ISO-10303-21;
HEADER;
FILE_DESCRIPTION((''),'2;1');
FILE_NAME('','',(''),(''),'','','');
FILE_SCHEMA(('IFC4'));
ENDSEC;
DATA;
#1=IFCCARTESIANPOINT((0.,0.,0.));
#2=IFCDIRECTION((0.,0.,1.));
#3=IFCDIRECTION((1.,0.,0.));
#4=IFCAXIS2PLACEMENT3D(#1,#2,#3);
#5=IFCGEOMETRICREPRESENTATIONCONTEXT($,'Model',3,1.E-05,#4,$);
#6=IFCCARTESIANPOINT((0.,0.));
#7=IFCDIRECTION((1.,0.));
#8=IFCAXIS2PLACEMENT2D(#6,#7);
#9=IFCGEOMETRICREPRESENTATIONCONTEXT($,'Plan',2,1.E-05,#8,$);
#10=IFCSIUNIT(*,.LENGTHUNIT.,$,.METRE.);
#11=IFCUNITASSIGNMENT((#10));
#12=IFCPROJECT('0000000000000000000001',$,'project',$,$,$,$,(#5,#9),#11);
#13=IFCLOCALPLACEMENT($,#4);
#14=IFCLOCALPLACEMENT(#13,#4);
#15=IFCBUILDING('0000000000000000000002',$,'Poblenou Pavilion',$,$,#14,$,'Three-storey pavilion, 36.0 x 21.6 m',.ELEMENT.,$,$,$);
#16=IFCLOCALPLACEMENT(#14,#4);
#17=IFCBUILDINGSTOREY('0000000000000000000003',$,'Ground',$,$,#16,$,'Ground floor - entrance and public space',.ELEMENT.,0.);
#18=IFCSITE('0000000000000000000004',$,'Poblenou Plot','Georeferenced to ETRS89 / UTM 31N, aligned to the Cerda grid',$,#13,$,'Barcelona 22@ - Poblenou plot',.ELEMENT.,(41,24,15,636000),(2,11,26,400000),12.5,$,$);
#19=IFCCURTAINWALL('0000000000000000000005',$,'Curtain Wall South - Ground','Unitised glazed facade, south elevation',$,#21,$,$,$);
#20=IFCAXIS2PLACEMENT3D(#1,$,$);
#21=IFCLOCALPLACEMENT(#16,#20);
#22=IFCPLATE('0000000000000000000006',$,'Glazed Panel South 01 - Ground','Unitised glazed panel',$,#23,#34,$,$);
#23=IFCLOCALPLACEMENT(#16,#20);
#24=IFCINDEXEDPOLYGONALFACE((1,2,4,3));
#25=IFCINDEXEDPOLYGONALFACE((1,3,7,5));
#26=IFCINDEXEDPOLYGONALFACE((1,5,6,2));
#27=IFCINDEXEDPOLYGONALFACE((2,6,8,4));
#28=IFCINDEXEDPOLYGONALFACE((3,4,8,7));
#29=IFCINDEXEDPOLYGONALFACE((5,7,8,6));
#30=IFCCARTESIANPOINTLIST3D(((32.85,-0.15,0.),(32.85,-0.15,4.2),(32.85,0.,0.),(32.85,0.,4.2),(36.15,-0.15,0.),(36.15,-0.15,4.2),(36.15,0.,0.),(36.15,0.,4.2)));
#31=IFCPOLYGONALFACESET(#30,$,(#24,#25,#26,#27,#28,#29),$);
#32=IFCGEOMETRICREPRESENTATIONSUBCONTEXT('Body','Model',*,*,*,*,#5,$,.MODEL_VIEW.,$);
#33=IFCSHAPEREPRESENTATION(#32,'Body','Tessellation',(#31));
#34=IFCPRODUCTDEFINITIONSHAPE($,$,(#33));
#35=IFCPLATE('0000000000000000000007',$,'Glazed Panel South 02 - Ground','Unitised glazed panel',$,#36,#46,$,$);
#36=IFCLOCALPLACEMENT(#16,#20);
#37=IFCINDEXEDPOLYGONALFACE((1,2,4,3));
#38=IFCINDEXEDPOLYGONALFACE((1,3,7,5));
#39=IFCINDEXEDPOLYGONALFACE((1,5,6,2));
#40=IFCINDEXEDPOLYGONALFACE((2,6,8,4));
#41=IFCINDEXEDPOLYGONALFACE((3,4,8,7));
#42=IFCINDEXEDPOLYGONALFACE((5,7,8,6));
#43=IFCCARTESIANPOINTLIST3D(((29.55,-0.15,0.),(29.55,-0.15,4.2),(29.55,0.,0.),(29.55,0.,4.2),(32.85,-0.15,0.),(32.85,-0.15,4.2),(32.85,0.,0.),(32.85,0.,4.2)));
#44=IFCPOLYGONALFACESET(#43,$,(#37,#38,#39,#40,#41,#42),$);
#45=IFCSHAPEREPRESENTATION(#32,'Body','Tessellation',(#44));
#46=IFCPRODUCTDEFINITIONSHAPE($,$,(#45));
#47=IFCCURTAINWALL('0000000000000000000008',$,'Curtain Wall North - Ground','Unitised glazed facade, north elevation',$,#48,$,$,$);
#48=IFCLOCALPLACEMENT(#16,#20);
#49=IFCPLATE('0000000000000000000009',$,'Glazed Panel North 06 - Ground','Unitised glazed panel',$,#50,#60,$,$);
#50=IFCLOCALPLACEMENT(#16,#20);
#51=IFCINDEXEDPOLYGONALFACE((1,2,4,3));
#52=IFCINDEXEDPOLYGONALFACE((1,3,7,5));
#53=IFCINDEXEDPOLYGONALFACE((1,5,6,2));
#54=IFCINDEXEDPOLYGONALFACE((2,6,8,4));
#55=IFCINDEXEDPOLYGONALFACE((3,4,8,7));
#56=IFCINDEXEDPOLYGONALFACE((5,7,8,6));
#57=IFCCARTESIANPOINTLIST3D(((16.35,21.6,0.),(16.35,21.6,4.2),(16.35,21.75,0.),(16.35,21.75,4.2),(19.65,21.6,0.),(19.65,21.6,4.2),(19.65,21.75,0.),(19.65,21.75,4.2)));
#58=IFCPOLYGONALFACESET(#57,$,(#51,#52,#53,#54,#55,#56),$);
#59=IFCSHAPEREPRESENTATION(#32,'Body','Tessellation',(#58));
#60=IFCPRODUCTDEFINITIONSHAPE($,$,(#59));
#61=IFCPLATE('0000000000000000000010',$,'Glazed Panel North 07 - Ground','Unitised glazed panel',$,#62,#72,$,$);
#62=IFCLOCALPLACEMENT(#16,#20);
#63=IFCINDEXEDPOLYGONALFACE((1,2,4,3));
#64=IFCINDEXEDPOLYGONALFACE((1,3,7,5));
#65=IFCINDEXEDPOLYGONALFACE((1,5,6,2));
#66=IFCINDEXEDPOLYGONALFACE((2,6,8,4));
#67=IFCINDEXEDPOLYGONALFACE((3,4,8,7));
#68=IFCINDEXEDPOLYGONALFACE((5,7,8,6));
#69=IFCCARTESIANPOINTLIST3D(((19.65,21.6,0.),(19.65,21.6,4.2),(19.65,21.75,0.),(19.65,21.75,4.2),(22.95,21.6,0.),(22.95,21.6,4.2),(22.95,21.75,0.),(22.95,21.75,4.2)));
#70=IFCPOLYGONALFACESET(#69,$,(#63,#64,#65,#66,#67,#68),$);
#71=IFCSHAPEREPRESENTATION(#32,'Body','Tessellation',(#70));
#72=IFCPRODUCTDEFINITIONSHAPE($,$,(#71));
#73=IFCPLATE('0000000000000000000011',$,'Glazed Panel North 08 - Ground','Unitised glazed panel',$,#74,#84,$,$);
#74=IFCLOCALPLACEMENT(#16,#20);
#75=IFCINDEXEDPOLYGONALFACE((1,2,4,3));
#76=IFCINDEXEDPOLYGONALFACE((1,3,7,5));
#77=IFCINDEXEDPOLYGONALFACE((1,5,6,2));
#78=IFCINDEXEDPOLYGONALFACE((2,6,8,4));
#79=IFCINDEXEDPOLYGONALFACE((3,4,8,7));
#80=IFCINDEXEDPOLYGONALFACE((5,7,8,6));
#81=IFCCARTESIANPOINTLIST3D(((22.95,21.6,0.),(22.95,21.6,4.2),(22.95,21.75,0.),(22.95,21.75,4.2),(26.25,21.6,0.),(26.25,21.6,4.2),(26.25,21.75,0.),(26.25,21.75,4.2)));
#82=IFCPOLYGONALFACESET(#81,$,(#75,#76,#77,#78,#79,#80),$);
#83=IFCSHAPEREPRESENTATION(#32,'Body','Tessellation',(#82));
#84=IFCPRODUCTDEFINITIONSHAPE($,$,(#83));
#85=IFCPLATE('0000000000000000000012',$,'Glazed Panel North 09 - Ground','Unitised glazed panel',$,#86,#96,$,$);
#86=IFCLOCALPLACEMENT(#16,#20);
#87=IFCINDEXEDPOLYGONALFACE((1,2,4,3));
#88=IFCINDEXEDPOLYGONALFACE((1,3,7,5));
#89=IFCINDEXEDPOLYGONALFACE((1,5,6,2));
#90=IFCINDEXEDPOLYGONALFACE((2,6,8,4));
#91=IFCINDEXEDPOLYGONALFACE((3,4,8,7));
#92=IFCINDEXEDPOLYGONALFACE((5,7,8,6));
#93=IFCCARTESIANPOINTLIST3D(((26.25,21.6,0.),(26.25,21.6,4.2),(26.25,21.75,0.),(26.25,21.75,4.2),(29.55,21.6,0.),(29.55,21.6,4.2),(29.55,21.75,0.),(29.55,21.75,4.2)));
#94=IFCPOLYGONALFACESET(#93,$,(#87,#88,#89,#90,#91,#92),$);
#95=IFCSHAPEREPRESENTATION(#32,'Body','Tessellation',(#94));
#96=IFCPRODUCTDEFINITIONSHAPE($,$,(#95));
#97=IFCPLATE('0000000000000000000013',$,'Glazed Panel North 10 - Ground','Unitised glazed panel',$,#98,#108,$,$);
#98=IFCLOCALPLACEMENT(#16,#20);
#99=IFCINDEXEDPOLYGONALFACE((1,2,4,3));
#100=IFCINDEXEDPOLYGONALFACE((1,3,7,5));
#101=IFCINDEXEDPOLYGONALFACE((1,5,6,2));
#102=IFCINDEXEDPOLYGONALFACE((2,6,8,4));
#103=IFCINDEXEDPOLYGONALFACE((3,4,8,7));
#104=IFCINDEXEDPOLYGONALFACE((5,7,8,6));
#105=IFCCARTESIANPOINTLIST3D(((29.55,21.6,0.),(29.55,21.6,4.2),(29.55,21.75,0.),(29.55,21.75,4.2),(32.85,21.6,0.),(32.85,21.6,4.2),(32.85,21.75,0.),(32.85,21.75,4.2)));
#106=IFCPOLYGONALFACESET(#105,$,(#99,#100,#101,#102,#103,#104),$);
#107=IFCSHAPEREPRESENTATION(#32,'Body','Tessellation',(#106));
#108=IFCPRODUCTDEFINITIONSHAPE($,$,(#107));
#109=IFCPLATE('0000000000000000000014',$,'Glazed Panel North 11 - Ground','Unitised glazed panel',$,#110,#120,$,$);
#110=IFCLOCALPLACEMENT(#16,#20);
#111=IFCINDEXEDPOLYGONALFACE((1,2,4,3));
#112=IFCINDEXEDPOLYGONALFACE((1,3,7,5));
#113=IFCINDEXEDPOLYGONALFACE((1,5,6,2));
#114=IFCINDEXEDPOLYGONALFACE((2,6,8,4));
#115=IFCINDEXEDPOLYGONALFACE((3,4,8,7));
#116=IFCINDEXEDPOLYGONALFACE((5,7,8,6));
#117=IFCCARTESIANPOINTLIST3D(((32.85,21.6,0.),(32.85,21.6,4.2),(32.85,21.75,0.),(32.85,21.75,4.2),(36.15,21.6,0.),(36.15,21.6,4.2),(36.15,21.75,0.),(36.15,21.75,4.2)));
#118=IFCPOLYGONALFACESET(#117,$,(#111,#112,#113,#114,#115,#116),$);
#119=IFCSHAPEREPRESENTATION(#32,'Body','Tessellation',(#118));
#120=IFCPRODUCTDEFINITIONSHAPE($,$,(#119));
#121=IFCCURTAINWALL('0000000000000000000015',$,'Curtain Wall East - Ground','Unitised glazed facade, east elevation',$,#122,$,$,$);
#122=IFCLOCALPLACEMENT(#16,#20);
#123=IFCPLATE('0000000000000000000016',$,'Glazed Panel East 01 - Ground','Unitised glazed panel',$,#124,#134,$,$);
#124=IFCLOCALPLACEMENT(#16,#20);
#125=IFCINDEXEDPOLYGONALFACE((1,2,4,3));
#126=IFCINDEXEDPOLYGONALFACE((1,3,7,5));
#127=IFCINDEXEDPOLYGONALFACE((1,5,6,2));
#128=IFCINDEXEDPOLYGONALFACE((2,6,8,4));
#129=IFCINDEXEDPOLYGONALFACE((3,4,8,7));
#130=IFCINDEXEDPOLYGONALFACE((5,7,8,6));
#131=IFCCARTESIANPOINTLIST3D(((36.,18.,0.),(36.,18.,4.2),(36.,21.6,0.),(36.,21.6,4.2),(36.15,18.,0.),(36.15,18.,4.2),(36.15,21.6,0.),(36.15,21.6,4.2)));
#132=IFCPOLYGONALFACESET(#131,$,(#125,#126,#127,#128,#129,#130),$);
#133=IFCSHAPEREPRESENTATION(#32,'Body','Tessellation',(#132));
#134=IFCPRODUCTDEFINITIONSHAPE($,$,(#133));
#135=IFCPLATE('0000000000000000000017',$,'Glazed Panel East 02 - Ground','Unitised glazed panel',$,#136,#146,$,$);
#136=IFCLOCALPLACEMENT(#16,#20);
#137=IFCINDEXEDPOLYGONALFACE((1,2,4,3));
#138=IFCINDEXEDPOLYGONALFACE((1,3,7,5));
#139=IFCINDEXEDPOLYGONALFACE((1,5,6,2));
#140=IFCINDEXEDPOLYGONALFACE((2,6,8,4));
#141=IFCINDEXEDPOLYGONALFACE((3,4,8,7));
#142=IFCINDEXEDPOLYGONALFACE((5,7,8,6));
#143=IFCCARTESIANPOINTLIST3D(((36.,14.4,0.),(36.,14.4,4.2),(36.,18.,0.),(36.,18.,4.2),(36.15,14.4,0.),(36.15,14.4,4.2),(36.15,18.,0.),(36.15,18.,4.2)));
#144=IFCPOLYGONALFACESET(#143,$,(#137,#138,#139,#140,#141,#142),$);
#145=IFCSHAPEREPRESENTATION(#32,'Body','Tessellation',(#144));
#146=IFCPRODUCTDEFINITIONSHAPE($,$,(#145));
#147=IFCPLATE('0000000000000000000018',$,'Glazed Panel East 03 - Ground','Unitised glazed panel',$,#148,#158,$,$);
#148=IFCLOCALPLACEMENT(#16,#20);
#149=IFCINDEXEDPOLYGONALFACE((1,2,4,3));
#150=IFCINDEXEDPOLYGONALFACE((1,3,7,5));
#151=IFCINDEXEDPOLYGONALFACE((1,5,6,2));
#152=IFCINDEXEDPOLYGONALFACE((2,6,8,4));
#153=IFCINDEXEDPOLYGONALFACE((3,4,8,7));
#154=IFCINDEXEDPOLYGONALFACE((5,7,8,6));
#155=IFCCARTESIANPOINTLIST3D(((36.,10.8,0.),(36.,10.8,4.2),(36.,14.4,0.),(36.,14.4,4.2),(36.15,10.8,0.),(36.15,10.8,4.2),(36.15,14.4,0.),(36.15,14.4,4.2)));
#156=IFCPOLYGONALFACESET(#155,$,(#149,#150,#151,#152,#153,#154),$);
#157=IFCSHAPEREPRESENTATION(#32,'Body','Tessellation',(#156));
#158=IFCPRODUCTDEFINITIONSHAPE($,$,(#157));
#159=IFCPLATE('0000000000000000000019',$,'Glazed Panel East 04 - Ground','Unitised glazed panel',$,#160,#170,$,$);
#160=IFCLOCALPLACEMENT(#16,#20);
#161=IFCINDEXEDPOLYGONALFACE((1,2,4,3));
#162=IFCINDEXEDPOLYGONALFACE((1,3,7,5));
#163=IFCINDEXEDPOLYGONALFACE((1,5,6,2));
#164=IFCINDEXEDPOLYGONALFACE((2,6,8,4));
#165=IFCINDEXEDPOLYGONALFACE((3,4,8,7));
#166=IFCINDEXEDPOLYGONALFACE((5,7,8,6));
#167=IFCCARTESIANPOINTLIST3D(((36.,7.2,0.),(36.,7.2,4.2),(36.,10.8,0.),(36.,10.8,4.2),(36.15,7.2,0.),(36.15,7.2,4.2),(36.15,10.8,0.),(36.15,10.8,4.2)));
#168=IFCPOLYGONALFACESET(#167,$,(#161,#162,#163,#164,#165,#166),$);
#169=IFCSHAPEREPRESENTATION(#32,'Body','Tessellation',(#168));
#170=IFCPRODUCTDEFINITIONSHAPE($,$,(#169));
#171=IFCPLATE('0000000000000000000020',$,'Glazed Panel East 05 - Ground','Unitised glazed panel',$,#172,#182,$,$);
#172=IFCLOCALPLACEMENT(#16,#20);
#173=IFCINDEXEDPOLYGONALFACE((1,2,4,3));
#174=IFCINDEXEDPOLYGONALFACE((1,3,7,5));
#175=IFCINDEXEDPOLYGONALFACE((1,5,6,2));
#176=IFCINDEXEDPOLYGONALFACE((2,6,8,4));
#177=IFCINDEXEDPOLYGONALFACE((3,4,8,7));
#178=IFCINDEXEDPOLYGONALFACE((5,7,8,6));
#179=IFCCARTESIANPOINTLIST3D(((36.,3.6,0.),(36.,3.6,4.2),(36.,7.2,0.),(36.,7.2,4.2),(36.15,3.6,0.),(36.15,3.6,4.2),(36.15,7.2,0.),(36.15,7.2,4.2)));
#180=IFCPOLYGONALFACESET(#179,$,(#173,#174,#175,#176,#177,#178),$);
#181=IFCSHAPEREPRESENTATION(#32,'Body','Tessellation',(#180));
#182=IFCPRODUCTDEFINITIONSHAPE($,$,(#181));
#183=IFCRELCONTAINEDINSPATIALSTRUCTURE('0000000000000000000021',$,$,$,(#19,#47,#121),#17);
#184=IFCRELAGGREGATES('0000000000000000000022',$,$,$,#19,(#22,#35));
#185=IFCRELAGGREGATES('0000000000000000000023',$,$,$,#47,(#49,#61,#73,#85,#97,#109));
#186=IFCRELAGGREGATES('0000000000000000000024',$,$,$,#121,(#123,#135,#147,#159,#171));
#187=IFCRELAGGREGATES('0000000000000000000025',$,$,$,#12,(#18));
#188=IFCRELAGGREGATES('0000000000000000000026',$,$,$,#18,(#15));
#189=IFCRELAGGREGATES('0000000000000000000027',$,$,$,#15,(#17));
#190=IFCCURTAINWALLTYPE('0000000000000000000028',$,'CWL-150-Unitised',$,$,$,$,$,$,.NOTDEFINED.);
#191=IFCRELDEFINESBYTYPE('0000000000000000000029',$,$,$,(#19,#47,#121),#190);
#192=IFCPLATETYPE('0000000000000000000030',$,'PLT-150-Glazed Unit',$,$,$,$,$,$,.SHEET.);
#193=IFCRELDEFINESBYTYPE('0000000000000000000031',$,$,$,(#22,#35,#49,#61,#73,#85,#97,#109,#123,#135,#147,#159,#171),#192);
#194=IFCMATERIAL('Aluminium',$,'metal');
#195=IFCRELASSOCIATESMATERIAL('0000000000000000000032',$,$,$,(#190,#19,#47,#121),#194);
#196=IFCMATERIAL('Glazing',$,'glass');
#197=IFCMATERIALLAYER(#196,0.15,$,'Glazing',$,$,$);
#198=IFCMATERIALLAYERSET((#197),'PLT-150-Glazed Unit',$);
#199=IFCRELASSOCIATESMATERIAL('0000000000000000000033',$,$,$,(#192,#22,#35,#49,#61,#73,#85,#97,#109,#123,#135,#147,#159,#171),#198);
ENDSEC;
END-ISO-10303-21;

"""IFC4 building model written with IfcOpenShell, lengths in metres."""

from ifc_helpers import new_model, si_unit, frame, origin_with_axes, origin_2d_with_axis, place, context, subcontext, project, spatial, line, indexed_curve, outline, extrude, material, layer, layer_set, layer_usage, type_object, element, aggregate, save


model = new_model("IFC4")

# Units and contexts
model_context = context("Model", 3, precision=1e-05, world=origin_with_axes())
plan_context = context("Plan", 2, precision=1e-05, world=origin_2d_with_axis())
body_context = subcontext(model_context, "Body", "Model", "MODEL_VIEW")
ifc_project = project(units=[si_unit("LENGTHUNIT", "METRE")], contexts=[model_context, plan_context])

# Site, building, storey
site_placement = place(None, origin_with_axes())
site = spatial("IfcSite", under=ifc_project, at=site_placement, Name="Poblenou Plot", Description="Georeferenced to ETRS89 / UTM 31N, aligned to the Cerda grid", LongName="Barcelona 22@ - Poblenou plot", CompositionType="ELEMENT", RefLatitude=(41, 24, 15, 636000), RefLongitude=(2, 11, 26, 400000), RefElevation=12.5)
building_placement = place(site_placement, origin_with_axes())
building = spatial("IfcBuilding", under=site, at=building_placement, Name="Poblenou Pavilion", LongName="Three-storey pavilion, 36.0 x 21.6 m", CompositionType="ELEMENT")
storey_placement = place(building_placement, origin_with_axes())
storey = spatial("IfcBuildingStorey", under=building, at=storey_placement, Name="Ground", LongName="Ground floor - entrance and public space", CompositionType="ELEMENT", Elevation=0.0)

# Curtain walls, plates
ifc_material_1 = material(Name="Aluminium", Category="metal")
curtain_wall_type = type_object("IfcCurtainWallType", Name="CWL-150-Unitised", PredefinedType="NOTDEFINED", material=ifc_material_1)
curtain_wall_1_placement = place(storey_placement, frame((36.15, 0.0, 0.0), z_axis=(0.0, 0.0, 1.0), x_axis=(-1.0, 0.0, 0.0)))
curtain_wall_1 = element("IfcCurtainWall", 1, at=curtain_wall_1_placement, inside=storey, type_object=curtain_wall_type, material=ifc_material_1, Name="Curtain Wall South - Ground", Description="Unitised glazed facade, south elevation")
ifc_material_2 = material(Name="Glazing", Category="glass")
ifc_layer_1 = layer(ifc_material_2, 0.15, Name="Glazing")
ifc_layer_set_1 = layer_set([ifc_layer_1], Name="PLT-150-Glazed Unit")
ifc_layer_usage_1 = layer_usage(ifc_layer_set_1, "AXIS2", "POSITIVE", 0.0)
plate_type = type_object("IfcPlateType", Name="PLT-150-Glazed Unit", PredefinedType="SHEET", material=ifc_layer_set_1)
plate_1_placement = place(curtain_wall_1_placement, origin_with_axes())
plate_1 = element("IfcPlate", 2, at=plate_1_placement, type_object=plate_type, material=ifc_layer_usage_1, Name="Glazed Panel South 01 - Ground", Description="Unitised glazed panel", context=body_context, shape_type="SweptSolid", body=[
    extrude(outline(indexed_curve([(0.0, 0.0), (3.3, 0.0), (3.3, 0.15), (0.0, 0.15)], segments=[line(1, 2, 3, 4, 1)])), origin_with_axes(), (0.0, 0.0, 1.0), 4.2),
])
ifc_layer_usage_2 = layer_usage(ifc_layer_set_1, "AXIS2", "POSITIVE", 0.0)
plate_2_placement = place(curtain_wall_1_placement, frame((3.3, 0.0, 0.0), z_axis=(0.0, 0.0, 1.0), x_axis=(1.0, 0.0, 0.0)))
plate_2 = element("IfcPlate", 3, at=plate_2_placement, type_object=plate_type, material=ifc_layer_usage_2, Name="Glazed Panel South 02 - Ground", Description="Unitised glazed panel", context=body_context, shape_type="SweptSolid", body=[
    extrude(outline(indexed_curve([(0.0, 0.0), (3.3, 0.0), (3.3, 0.15), (0.0, 0.15)], segments=[line(1, 2, 3, 4, 1)])), origin_with_axes(), (0.0, 0.0, 1.0), 4.2),
])
aggregate(curtain_wall_1, [plate_1, plate_2])
curtain_wall_2_placement = place(storey_placement, frame((-0.15, 21.6, 0.0), z_axis=(0.0, 0.0, 1.0), x_axis=(1.0, 0.0, 0.0)))
curtain_wall_2 = element("IfcCurtainWall", 4, at=curtain_wall_2_placement, inside=storey, type_object=curtain_wall_type, material=ifc_material_1, Name="Curtain Wall North - Ground", Description="Unitised glazed facade, north elevation")
ifc_layer_usage_3 = layer_usage(ifc_layer_set_1, "AXIS2", "POSITIVE", 0.0)
plate_3_placement = place(curtain_wall_2_placement, frame((16.5, 0.0, 0.0), z_axis=(0.0, 0.0, 1.0), x_axis=(1.0, 0.0, 0.0)))
plate_3 = element("IfcPlate", 5, at=plate_3_placement, type_object=plate_type, material=ifc_layer_usage_3, Name="Glazed Panel North 06 - Ground", Description="Unitised glazed panel", context=body_context, shape_type="SweptSolid", body=[
    extrude(outline(indexed_curve([(0.0, 0.0), (3.3, 0.0), (3.3, 0.15), (0.0, 0.15)], segments=[line(1, 2, 3, 4, 1)])), origin_with_axes(), (0.0, 0.0, 1.0), 4.2),
])
ifc_layer_usage_4 = layer_usage(ifc_layer_set_1, "AXIS2", "POSITIVE", 0.0)
plate_4_placement = place(curtain_wall_2_placement, frame((19.8, 0.0, 0.0), z_axis=(0.0, 0.0, 1.0), x_axis=(1.0, 0.0, 0.0)))
plate_4 = element("IfcPlate", 6, at=plate_4_placement, type_object=plate_type, material=ifc_layer_usage_4, Name="Glazed Panel North 07 - Ground", Description="Unitised glazed panel", context=body_context, shape_type="SweptSolid", body=[
    extrude(outline(indexed_curve([(0.0, 0.0), (3.3, 0.0), (3.3, 0.15), (0.0, 0.15)], segments=[line(1, 2, 3, 4, 1)])), origin_with_axes(), (0.0, 0.0, 1.0), 4.2),
])
ifc_layer_usage_5 = layer_usage(ifc_layer_set_1, "AXIS2", "POSITIVE", 0.0)
plate_5_placement = place(curtain_wall_2_placement, frame((23.1, 0.0, 0.0), z_axis=(0.0, 0.0, 1.0), x_axis=(1.0, 0.0, 0.0)))
plate_5 = element("IfcPlate", 7, at=plate_5_placement, type_object=plate_type, material=ifc_layer_usage_5, Name="Glazed Panel North 08 - Ground", Description="Unitised glazed panel", context=body_context, shape_type="SweptSolid", body=[
    extrude(outline(indexed_curve([(0.0, 0.0), (3.3, 0.0), (3.3, 0.15), (0.0, 0.15)], segments=[line(1, 2, 3, 4, 1)])), origin_with_axes(), (0.0, 0.0, 1.0), 4.2),
])
ifc_layer_usage_6 = layer_usage(ifc_layer_set_1, "AXIS2", "POSITIVE", 0.0)
plate_6_placement = place(curtain_wall_2_placement, frame((26.4, 0.0, 0.0), z_axis=(0.0, 0.0, 1.0), x_axis=(1.0, 0.0, 0.0)))
plate_6 = element("IfcPlate", 8, at=plate_6_placement, type_object=plate_type, material=ifc_layer_usage_6, Name="Glazed Panel North 09 - Ground", Description="Unitised glazed panel", context=body_context, shape_type="SweptSolid", body=[
    extrude(outline(indexed_curve([(0.0, 0.0), (3.3, 0.0), (3.3, 0.15), (0.0, 0.15)], segments=[line(1, 2, 3, 4, 1)])), origin_with_axes(), (0.0, 0.0, 1.0), 4.2),
])
ifc_layer_usage_7 = layer_usage(ifc_layer_set_1, "AXIS2", "POSITIVE", 0.0)
plate_7_placement = place(curtain_wall_2_placement, frame((29.7, 0.0, 0.0), z_axis=(0.0, 0.0, 1.0), x_axis=(1.0, 0.0, 0.0)))
plate_7 = element("IfcPlate", 9, at=plate_7_placement, type_object=plate_type, material=ifc_layer_usage_7, Name="Glazed Panel North 10 - Ground", Description="Unitised glazed panel", context=body_context, shape_type="SweptSolid", body=[
    extrude(outline(indexed_curve([(0.0, 0.0), (3.3, 0.0), (3.3, 0.15), (0.0, 0.15)], segments=[line(1, 2, 3, 4, 1)])), origin_with_axes(), (0.0, 0.0, 1.0), 4.2),
])
ifc_layer_usage_8 = layer_usage(ifc_layer_set_1, "AXIS2", "POSITIVE", 0.0)
plate_8_placement = place(curtain_wall_2_placement, frame((33.0, 0.0, 0.0), z_axis=(0.0, 0.0, 1.0), x_axis=(1.0, 0.0, 0.0)))
plate_8 = element("IfcPlate", 10, at=plate_8_placement, type_object=plate_type, material=ifc_layer_usage_8, Name="Glazed Panel North 11 - Ground", Description="Unitised glazed panel", context=body_context, shape_type="SweptSolid", body=[
    extrude(outline(indexed_curve([(0.0, 0.0), (3.3, 0.0), (3.3, 0.15), (0.0, 0.15)], segments=[line(1, 2, 3, 4, 1)])), origin_with_axes(), (0.0, 0.0, 1.0), 4.2),
])
aggregate(curtain_wall_2, [plate_3, plate_4, plate_5, plate_6, plate_7, plate_8])
curtain_wall_3_placement = place(storey_placement, frame((36.0, 21.6, 0.0), z_axis=(0.0, 0.0, 1.0), x_axis=(0.0, -1.0, 0.0)))
curtain_wall_3 = element("IfcCurtainWall", 11, at=curtain_wall_3_placement, inside=storey, type_object=curtain_wall_type, material=ifc_material_1, Name="Curtain Wall East - Ground", Description="Unitised glazed facade, east elevation")
ifc_layer_usage_9 = layer_usage(ifc_layer_set_1, "AXIS2", "POSITIVE", 0.0)
plate_9_placement = place(curtain_wall_3_placement, origin_with_axes())
plate_9 = element("IfcPlate", 12, at=plate_9_placement, type_object=plate_type, material=ifc_layer_usage_9, Name="Glazed Panel East 01 - Ground", Description="Unitised glazed panel", context=body_context, shape_type="SweptSolid", body=[
    extrude(outline(indexed_curve([(0.0, 0.0), (3.6, 0.0), (3.6, 0.15), (0.0, 0.15)], segments=[line(1, 2, 3, 4, 1)])), origin_with_axes(), (0.0, 0.0, 1.0), 4.2),
])
ifc_layer_usage_10 = layer_usage(ifc_layer_set_1, "AXIS2", "POSITIVE", 0.0)
plate_10_placement = place(curtain_wall_3_placement, frame((3.6, 0.0, 0.0), z_axis=(0.0, 0.0, 1.0), x_axis=(1.0, 0.0, 0.0)))
plate_10 = element("IfcPlate", 13, at=plate_10_placement, type_object=plate_type, material=ifc_layer_usage_10, Name="Glazed Panel East 02 - Ground", Description="Unitised glazed panel", context=body_context, shape_type="SweptSolid", body=[
    extrude(outline(indexed_curve([(0.0, 0.0), (3.6, 0.0), (3.6, 0.15), (0.0, 0.15)], segments=[line(1, 2, 3, 4, 1)])), origin_with_axes(), (0.0, 0.0, 1.0), 4.2),
])
ifc_layer_usage_11 = layer_usage(ifc_layer_set_1, "AXIS2", "POSITIVE", 0.0)
plate_11_placement = place(curtain_wall_3_placement, frame((7.2, 0.0, 0.0), z_axis=(0.0, 0.0, 1.0), x_axis=(1.0, 0.0, 0.0)))
plate_11 = element("IfcPlate", 14, at=plate_11_placement, type_object=plate_type, material=ifc_layer_usage_11, Name="Glazed Panel East 03 - Ground", Description="Unitised glazed panel", context=body_context, shape_type="SweptSolid", body=[
    extrude(outline(indexed_curve([(0.0, 0.0), (3.6, 0.0), (3.6, 0.15), (0.0, 0.15)], segments=[line(1, 2, 3, 4, 1)])), origin_with_axes(), (0.0, 0.0, 1.0), 4.2),
])
ifc_layer_usage_12 = layer_usage(ifc_layer_set_1, "AXIS2", "POSITIVE", 0.0)
plate_12_placement = place(curtain_wall_3_placement, frame((10.8, 0.0, 0.0), z_axis=(0.0, 0.0, 1.0), x_axis=(1.0, 0.0, 0.0)))
plate_12 = element("IfcPlate", 15, at=plate_12_placement, type_object=plate_type, material=ifc_layer_usage_12, Name="Glazed Panel East 04 - Ground", Description="Unitised glazed panel", context=body_context, shape_type="SweptSolid", body=[
    extrude(outline(indexed_curve([(0.0, 0.0), (3.6, 0.0), (3.6, 0.15), (0.0, 0.15)], segments=[line(1, 2, 3, 4, 1)])), origin_with_axes(), (0.0, 0.0, 1.0), 4.2),
])
ifc_layer_usage_13 = layer_usage(ifc_layer_set_1, "AXIS2", "POSITIVE", 0.0)
plate_13_placement = place(curtain_wall_3_placement, frame((14.4, 0.0, 0.0), z_axis=(0.0, 0.0, 1.0), x_axis=(1.0, 0.0, 0.0)))
plate_13 = element("IfcPlate", 16, at=plate_13_placement, type_object=plate_type, material=ifc_layer_usage_13, Name="Glazed Panel East 05 - Ground", Description="Unitised glazed panel", context=body_context, shape_type="SweptSolid", body=[
    extrude(outline(indexed_curve([(0.0, 0.0), (3.6, 0.0), (3.6, 0.15), (0.0, 0.15)], segments=[line(1, 2, 3, 4, 1)])), origin_with_axes(), (0.0, 0.0, 1.0), 4.2),
])
aggregate(curtain_wall_3, [plate_9, plate_10, plate_11, plate_12, plate_13])

save(model, "model.ifc")
